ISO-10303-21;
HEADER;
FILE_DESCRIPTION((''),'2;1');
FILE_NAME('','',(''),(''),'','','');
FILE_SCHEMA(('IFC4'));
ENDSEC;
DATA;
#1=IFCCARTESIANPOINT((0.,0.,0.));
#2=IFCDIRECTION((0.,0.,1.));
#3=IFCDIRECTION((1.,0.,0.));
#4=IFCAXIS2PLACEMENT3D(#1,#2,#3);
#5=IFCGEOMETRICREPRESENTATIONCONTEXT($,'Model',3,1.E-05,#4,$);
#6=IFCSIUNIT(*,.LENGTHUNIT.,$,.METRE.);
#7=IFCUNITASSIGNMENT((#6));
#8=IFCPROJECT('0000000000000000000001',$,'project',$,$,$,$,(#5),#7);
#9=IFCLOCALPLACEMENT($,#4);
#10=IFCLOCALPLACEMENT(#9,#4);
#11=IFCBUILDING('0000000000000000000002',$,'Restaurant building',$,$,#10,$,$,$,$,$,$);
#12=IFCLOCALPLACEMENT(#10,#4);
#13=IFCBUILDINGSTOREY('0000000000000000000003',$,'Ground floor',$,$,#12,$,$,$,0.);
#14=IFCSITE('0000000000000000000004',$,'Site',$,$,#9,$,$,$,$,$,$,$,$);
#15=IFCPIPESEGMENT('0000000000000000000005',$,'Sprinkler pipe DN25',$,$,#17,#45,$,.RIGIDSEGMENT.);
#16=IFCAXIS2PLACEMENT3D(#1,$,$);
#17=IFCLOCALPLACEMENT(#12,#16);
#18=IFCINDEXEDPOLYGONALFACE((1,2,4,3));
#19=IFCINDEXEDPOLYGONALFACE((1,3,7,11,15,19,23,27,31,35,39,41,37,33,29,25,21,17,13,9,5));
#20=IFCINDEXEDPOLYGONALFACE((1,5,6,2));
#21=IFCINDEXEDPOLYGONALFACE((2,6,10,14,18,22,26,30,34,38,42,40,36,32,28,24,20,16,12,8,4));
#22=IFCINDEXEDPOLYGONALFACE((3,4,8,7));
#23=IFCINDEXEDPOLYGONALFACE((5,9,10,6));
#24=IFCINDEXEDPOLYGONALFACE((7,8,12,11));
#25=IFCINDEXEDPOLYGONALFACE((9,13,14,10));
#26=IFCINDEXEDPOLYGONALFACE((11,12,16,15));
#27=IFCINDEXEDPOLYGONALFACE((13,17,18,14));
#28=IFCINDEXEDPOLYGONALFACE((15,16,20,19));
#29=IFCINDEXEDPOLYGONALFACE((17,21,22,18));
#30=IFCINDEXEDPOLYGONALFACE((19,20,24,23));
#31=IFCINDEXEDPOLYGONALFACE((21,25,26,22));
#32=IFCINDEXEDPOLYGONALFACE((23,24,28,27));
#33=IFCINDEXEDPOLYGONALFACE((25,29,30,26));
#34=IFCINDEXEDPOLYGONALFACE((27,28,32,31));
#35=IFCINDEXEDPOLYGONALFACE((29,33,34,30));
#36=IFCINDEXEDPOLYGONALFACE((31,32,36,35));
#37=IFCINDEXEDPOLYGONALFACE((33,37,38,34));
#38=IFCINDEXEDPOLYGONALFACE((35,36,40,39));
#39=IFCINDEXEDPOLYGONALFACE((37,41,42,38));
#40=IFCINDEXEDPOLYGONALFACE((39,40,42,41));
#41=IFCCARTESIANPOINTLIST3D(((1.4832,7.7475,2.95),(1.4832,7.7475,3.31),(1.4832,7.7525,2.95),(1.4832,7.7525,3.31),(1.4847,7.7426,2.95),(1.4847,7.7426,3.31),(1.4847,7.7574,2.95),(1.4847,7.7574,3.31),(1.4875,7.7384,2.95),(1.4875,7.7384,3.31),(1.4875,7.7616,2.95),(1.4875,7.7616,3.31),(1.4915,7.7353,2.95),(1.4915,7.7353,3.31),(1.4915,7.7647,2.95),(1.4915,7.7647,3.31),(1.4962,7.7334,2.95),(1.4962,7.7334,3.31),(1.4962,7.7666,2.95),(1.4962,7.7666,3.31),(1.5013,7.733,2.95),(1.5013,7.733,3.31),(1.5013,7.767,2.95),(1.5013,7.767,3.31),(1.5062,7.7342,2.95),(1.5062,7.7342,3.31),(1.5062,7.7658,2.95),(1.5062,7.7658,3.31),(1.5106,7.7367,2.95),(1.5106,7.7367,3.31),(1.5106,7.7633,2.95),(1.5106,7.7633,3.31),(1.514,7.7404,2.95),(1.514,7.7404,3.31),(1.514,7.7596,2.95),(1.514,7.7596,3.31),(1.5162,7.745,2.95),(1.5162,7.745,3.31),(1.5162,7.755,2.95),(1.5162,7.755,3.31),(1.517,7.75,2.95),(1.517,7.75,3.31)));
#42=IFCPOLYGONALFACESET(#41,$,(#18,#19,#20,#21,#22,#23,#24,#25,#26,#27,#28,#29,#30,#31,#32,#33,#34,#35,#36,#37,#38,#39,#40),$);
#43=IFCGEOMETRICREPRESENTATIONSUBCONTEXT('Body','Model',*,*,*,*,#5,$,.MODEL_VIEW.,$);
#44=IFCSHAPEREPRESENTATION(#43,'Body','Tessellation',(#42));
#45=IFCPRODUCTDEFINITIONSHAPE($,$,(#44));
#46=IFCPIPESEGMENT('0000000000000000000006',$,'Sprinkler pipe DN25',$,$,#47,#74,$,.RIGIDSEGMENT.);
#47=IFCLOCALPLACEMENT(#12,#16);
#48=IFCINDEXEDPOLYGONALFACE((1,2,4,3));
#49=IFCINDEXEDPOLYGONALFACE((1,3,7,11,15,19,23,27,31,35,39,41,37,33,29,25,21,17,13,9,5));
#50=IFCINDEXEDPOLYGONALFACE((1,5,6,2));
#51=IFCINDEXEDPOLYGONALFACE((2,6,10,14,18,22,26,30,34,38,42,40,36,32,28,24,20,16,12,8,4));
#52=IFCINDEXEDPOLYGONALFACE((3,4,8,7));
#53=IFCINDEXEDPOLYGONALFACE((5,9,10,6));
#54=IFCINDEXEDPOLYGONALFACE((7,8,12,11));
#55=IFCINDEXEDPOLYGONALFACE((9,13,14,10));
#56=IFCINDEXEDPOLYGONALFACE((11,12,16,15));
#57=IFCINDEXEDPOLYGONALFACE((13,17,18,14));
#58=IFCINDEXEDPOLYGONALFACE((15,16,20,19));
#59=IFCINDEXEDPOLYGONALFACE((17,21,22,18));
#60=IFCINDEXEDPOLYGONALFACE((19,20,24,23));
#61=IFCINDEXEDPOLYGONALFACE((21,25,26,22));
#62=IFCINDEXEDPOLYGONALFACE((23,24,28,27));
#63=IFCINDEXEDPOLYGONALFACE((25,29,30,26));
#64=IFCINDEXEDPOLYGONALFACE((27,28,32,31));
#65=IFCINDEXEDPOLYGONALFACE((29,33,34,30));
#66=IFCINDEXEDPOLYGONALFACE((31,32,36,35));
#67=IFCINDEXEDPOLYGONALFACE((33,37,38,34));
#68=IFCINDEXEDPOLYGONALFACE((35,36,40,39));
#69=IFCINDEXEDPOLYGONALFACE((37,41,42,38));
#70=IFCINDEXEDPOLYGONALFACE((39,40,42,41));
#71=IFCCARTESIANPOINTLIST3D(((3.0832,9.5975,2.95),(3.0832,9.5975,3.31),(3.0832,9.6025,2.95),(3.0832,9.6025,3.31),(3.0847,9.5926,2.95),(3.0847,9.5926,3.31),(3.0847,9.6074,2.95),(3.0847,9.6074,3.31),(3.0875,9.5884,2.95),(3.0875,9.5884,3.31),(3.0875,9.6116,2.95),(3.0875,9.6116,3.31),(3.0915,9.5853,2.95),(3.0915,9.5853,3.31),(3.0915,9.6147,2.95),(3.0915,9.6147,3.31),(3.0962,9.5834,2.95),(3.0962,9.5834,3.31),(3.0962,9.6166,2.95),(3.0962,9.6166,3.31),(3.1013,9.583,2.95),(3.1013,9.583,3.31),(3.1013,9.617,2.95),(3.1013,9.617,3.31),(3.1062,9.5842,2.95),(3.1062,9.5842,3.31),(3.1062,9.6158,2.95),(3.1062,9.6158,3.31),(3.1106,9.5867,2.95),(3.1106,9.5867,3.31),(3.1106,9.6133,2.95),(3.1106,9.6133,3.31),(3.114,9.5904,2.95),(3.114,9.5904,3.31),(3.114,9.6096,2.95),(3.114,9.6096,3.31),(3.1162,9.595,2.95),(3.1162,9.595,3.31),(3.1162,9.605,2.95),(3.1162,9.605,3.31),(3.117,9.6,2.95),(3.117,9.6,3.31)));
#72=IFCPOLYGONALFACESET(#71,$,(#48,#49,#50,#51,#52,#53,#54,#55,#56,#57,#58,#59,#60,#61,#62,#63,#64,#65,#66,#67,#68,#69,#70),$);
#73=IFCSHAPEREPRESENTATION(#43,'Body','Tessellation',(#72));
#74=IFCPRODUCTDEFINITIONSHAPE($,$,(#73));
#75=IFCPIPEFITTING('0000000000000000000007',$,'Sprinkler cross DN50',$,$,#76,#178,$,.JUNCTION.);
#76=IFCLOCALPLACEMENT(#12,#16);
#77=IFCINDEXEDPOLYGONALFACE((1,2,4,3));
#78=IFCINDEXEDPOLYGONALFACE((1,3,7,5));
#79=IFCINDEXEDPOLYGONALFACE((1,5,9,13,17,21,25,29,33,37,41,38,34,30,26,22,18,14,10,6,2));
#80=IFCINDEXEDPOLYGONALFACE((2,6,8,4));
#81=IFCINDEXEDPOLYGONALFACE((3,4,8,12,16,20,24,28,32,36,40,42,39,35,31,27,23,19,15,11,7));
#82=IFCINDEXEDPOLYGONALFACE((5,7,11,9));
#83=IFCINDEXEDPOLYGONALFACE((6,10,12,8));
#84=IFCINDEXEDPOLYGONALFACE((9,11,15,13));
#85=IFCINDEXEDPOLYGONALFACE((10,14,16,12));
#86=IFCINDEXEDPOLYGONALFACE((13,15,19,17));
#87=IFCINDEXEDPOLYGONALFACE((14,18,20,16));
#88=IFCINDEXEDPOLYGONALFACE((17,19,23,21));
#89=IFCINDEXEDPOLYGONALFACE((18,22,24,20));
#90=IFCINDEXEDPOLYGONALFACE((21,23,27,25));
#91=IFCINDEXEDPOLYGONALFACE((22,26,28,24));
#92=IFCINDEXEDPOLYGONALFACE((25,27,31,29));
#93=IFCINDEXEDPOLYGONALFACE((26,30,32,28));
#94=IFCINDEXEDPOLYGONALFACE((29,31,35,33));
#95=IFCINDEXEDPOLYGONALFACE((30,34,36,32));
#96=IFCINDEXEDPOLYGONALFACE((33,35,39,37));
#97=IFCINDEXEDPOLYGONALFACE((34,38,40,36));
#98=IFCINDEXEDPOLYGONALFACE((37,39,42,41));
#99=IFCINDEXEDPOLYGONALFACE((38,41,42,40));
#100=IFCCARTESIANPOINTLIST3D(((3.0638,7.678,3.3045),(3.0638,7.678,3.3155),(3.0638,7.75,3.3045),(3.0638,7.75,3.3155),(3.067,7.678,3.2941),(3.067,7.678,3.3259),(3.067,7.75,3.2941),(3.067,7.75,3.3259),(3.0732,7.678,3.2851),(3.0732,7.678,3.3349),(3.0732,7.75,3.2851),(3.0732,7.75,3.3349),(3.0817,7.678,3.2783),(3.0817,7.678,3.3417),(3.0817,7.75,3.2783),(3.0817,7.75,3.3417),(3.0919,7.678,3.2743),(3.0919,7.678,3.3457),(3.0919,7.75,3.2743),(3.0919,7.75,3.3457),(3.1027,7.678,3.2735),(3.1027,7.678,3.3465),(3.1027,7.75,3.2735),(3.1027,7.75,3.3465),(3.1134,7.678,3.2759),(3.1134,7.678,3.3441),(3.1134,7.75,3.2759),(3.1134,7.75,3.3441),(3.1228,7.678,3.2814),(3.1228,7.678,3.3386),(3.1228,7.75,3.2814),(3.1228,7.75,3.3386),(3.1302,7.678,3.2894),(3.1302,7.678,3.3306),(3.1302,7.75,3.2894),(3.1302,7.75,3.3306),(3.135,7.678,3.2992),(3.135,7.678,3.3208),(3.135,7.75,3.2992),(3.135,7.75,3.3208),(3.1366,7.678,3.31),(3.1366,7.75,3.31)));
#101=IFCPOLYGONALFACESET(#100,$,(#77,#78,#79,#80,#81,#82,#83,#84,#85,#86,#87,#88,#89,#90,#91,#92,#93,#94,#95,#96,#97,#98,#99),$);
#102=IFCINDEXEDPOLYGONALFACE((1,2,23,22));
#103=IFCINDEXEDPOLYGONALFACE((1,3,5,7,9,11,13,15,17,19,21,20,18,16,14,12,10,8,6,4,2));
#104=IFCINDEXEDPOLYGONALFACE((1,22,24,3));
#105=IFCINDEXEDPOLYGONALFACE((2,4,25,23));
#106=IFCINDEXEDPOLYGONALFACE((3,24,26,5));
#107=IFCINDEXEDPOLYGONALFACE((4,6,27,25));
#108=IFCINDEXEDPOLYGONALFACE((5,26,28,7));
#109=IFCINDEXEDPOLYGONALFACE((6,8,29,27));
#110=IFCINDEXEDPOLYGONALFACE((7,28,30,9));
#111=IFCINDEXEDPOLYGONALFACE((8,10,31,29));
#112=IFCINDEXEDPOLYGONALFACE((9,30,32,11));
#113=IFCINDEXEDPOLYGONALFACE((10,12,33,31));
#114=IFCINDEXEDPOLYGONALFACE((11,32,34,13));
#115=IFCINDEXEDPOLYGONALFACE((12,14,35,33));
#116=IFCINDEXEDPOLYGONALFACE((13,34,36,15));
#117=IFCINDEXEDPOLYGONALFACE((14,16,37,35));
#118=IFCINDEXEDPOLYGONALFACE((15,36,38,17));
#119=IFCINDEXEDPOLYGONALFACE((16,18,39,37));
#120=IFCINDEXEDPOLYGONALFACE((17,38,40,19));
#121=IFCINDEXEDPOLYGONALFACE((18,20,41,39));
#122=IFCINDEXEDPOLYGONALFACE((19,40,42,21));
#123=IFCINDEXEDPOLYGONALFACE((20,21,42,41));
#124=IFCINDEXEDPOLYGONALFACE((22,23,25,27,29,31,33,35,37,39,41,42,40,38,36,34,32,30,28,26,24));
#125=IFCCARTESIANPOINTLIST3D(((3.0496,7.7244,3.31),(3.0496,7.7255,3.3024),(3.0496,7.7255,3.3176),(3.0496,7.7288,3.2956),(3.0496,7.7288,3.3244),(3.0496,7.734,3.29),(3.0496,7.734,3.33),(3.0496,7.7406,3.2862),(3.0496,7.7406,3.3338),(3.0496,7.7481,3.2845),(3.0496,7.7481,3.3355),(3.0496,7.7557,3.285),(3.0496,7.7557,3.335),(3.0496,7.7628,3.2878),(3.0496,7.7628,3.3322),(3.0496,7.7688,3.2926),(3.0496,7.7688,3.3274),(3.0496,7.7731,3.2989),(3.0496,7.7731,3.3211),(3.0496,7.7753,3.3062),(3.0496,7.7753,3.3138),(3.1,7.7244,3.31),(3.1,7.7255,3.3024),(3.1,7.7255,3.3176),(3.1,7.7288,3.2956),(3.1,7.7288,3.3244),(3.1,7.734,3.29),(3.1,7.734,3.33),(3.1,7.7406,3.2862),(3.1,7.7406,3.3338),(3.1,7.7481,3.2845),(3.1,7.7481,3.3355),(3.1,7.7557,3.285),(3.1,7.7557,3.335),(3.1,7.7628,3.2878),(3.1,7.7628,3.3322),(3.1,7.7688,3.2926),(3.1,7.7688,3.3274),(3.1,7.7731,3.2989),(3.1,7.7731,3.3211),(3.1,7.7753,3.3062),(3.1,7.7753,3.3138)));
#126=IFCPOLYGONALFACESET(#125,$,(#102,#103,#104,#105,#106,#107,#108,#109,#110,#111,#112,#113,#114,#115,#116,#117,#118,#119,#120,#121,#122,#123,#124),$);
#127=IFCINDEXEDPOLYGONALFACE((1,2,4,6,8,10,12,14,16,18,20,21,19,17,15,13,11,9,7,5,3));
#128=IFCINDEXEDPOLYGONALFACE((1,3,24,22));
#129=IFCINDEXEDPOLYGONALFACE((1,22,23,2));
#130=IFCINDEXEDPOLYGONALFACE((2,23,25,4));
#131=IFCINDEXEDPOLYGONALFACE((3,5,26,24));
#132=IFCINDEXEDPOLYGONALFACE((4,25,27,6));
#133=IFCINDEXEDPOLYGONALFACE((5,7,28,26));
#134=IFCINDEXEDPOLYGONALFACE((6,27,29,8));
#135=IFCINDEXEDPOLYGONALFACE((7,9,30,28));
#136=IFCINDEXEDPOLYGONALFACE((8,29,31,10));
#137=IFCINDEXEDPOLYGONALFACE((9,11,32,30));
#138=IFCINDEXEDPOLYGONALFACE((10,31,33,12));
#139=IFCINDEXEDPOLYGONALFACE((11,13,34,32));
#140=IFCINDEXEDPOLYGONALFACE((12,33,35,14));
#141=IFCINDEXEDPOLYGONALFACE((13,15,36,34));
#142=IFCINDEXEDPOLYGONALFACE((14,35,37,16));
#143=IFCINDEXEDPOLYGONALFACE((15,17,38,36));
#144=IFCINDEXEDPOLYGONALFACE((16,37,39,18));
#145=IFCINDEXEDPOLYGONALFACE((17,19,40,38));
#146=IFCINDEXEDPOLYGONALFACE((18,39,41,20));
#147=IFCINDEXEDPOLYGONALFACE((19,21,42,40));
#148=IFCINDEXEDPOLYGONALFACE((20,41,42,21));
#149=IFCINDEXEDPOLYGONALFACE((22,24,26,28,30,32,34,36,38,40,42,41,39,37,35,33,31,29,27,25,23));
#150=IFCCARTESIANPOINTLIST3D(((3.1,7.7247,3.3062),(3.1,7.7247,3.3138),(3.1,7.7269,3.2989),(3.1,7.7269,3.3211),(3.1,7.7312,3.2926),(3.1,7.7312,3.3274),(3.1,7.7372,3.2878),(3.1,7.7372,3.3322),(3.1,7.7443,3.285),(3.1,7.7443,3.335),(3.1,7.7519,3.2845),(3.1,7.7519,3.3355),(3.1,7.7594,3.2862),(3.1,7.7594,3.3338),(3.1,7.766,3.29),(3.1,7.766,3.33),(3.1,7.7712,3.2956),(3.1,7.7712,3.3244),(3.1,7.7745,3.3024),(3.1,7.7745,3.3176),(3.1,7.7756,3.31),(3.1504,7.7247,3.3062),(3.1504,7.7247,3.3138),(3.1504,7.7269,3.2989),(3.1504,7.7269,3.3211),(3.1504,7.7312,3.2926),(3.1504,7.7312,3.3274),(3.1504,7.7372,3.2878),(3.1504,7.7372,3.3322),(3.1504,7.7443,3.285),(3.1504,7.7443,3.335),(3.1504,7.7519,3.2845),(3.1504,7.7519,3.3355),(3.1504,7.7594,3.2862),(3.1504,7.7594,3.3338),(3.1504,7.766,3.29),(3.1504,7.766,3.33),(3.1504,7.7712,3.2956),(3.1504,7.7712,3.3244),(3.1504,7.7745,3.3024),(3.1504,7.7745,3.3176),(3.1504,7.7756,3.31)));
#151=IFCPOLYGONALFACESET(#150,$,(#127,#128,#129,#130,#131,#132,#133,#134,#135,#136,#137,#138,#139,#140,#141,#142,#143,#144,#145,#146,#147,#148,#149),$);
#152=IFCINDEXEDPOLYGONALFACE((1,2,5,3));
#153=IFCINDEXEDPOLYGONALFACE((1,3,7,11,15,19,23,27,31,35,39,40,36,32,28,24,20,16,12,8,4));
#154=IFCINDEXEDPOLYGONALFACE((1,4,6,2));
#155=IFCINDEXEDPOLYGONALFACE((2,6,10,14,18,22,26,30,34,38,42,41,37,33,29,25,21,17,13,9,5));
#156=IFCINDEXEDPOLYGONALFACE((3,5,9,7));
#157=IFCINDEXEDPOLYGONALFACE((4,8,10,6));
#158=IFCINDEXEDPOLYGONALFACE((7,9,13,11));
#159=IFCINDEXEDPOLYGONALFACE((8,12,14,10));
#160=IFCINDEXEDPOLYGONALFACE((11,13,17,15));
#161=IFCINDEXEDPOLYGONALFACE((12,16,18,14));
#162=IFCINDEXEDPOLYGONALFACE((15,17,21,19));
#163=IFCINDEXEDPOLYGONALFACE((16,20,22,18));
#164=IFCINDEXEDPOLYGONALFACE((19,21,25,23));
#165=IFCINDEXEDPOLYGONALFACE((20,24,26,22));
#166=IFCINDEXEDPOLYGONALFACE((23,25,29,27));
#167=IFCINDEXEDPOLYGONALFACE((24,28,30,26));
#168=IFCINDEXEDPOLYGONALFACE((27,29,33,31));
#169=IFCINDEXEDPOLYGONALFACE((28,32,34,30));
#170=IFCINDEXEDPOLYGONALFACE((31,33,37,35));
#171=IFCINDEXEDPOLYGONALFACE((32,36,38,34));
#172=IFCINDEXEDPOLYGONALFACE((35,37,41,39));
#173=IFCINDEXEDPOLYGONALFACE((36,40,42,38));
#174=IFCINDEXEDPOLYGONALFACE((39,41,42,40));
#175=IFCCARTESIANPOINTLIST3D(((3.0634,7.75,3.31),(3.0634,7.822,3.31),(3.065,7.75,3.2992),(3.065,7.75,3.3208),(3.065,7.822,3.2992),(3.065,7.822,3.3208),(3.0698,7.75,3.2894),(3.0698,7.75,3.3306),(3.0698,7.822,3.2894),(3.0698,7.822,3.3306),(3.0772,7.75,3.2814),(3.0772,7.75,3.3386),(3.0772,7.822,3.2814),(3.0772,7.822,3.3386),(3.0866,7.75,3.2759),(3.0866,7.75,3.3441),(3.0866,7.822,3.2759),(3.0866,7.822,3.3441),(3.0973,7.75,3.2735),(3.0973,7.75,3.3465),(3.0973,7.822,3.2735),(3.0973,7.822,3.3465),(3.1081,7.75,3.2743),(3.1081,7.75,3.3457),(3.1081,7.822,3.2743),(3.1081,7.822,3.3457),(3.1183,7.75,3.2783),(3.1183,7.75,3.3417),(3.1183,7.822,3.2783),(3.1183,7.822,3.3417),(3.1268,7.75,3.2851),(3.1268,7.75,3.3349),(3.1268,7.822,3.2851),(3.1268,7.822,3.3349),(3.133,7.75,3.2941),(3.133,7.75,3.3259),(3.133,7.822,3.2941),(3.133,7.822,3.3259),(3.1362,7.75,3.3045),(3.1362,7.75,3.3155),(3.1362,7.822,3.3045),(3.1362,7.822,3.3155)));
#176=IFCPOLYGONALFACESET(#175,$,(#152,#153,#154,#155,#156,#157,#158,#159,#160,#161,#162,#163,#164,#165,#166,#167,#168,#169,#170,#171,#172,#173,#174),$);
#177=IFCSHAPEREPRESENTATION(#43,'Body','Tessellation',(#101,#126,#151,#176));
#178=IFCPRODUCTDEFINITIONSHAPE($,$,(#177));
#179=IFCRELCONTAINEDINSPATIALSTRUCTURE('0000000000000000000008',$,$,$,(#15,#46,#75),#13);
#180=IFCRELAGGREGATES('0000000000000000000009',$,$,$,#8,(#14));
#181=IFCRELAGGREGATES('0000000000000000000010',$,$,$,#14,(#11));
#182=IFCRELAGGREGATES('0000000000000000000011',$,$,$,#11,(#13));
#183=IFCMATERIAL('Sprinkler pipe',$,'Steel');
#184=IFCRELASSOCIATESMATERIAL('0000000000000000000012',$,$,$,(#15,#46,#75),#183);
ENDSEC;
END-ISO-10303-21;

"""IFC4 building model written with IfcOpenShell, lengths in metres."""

from ifc_helpers import new_model, si_unit, frame, origin_with_axes, origin_2d, place, context, subcontext, project, spatial, circle, extrude, material, element, save


model = new_model("IFC4")

# Units and contexts
model_context = context("Model", 3, precision=1e-05, world=origin_with_axes())
body_context = subcontext(model_context, "Body", "Model", "MODEL_VIEW")
ifc_project = project(units=[si_unit("LENGTHUNIT", "METRE")], contexts=[model_context])

# Site, building, storey
site_placement = place(None, origin_with_axes())
site = spatial("IfcSite", under=ifc_project, at=site_placement, Name="Site")
building_placement = place(site_placement, origin_with_axes())
building = spatial("IfcBuilding", under=site, at=building_placement, Name="Restaurant building")
storey_placement = place(building_placement, origin_with_axes())
storey = spatial("IfcBuildingStorey", under=building, at=storey_placement, Name="Ground floor", Elevation=0.0)

# Pipe segments
ifc_material_1 = material(Name="Sprinkler pipe", Category="Steel")
for number, where, name in (
    (1, (1.5, 7.75, 3.31), "Sprinkler pipe DN25"),
    (2, (3.1, 9.6, 3.31), "Sprinkler pipe DN25"),
):
    element("IfcPipeSegment", number, at=place(storey_placement, frame(where)), inside=storey, material=ifc_material_1, Name=name, PredefinedType="RIGIDSEGMENT", context=body_context, shape_type="SweptSolid", body=[
        extrude(circle(Radius=0.017, at=origin_2d()), frame((0.0, 0.0, 0.0), z_axis=(0.0, 0.0, -1.0), x_axis=(1.0, 0.0, 0.0)), (0.0, 0.0, 1.0), 0.36),
    ])

# Pipe fitting
pipe_fitting_1_placement = place(storey_placement, frame((3.1, 7.75, 3.31)))
element("IfcPipeFitting", 3, at=pipe_fitting_1_placement, inside=storey, material=ifc_material_1, Name="Sprinkler cross DN50", PredefinedType="JUNCTION", context=body_context, shape_type="SweptSolid", body=[
    extrude(circle(Radius=0.0366, at=origin_2d()), frame((0.0, 0.0, 0.0), z_axis=(0.0, -1.0, 0.0), x_axis=(1.0, 0.0, 0.0)), (0.0, 0.0, 1.0), 0.072),
    extrude(circle(Radius=0.0256, at=origin_2d()), frame((0.0, 0.0, 0.0), z_axis=(-1.0, 0.0, 0.0), x_axis=(0.0, -1.0, 0.0)), (0.0, 0.0, 1.0), 0.0504),
    extrude(circle(Radius=0.0256, at=origin_2d()), frame((0.0, 0.0, 0.0), z_axis=(1.0, 0.0, 0.0), x_axis=(0.0, 1.0, 0.0)), (0.0, 0.0, 1.0), 0.0504),
    extrude(circle(Radius=0.0366, at=origin_2d()), frame((0.0, 0.0, 0.0), z_axis=(0.0, 1.0, 0.0), x_axis=(-1.0, 0.0, 0.0)), (0.0, 0.0, 1.0), 0.072),
])

save(model, "model.ifc")
